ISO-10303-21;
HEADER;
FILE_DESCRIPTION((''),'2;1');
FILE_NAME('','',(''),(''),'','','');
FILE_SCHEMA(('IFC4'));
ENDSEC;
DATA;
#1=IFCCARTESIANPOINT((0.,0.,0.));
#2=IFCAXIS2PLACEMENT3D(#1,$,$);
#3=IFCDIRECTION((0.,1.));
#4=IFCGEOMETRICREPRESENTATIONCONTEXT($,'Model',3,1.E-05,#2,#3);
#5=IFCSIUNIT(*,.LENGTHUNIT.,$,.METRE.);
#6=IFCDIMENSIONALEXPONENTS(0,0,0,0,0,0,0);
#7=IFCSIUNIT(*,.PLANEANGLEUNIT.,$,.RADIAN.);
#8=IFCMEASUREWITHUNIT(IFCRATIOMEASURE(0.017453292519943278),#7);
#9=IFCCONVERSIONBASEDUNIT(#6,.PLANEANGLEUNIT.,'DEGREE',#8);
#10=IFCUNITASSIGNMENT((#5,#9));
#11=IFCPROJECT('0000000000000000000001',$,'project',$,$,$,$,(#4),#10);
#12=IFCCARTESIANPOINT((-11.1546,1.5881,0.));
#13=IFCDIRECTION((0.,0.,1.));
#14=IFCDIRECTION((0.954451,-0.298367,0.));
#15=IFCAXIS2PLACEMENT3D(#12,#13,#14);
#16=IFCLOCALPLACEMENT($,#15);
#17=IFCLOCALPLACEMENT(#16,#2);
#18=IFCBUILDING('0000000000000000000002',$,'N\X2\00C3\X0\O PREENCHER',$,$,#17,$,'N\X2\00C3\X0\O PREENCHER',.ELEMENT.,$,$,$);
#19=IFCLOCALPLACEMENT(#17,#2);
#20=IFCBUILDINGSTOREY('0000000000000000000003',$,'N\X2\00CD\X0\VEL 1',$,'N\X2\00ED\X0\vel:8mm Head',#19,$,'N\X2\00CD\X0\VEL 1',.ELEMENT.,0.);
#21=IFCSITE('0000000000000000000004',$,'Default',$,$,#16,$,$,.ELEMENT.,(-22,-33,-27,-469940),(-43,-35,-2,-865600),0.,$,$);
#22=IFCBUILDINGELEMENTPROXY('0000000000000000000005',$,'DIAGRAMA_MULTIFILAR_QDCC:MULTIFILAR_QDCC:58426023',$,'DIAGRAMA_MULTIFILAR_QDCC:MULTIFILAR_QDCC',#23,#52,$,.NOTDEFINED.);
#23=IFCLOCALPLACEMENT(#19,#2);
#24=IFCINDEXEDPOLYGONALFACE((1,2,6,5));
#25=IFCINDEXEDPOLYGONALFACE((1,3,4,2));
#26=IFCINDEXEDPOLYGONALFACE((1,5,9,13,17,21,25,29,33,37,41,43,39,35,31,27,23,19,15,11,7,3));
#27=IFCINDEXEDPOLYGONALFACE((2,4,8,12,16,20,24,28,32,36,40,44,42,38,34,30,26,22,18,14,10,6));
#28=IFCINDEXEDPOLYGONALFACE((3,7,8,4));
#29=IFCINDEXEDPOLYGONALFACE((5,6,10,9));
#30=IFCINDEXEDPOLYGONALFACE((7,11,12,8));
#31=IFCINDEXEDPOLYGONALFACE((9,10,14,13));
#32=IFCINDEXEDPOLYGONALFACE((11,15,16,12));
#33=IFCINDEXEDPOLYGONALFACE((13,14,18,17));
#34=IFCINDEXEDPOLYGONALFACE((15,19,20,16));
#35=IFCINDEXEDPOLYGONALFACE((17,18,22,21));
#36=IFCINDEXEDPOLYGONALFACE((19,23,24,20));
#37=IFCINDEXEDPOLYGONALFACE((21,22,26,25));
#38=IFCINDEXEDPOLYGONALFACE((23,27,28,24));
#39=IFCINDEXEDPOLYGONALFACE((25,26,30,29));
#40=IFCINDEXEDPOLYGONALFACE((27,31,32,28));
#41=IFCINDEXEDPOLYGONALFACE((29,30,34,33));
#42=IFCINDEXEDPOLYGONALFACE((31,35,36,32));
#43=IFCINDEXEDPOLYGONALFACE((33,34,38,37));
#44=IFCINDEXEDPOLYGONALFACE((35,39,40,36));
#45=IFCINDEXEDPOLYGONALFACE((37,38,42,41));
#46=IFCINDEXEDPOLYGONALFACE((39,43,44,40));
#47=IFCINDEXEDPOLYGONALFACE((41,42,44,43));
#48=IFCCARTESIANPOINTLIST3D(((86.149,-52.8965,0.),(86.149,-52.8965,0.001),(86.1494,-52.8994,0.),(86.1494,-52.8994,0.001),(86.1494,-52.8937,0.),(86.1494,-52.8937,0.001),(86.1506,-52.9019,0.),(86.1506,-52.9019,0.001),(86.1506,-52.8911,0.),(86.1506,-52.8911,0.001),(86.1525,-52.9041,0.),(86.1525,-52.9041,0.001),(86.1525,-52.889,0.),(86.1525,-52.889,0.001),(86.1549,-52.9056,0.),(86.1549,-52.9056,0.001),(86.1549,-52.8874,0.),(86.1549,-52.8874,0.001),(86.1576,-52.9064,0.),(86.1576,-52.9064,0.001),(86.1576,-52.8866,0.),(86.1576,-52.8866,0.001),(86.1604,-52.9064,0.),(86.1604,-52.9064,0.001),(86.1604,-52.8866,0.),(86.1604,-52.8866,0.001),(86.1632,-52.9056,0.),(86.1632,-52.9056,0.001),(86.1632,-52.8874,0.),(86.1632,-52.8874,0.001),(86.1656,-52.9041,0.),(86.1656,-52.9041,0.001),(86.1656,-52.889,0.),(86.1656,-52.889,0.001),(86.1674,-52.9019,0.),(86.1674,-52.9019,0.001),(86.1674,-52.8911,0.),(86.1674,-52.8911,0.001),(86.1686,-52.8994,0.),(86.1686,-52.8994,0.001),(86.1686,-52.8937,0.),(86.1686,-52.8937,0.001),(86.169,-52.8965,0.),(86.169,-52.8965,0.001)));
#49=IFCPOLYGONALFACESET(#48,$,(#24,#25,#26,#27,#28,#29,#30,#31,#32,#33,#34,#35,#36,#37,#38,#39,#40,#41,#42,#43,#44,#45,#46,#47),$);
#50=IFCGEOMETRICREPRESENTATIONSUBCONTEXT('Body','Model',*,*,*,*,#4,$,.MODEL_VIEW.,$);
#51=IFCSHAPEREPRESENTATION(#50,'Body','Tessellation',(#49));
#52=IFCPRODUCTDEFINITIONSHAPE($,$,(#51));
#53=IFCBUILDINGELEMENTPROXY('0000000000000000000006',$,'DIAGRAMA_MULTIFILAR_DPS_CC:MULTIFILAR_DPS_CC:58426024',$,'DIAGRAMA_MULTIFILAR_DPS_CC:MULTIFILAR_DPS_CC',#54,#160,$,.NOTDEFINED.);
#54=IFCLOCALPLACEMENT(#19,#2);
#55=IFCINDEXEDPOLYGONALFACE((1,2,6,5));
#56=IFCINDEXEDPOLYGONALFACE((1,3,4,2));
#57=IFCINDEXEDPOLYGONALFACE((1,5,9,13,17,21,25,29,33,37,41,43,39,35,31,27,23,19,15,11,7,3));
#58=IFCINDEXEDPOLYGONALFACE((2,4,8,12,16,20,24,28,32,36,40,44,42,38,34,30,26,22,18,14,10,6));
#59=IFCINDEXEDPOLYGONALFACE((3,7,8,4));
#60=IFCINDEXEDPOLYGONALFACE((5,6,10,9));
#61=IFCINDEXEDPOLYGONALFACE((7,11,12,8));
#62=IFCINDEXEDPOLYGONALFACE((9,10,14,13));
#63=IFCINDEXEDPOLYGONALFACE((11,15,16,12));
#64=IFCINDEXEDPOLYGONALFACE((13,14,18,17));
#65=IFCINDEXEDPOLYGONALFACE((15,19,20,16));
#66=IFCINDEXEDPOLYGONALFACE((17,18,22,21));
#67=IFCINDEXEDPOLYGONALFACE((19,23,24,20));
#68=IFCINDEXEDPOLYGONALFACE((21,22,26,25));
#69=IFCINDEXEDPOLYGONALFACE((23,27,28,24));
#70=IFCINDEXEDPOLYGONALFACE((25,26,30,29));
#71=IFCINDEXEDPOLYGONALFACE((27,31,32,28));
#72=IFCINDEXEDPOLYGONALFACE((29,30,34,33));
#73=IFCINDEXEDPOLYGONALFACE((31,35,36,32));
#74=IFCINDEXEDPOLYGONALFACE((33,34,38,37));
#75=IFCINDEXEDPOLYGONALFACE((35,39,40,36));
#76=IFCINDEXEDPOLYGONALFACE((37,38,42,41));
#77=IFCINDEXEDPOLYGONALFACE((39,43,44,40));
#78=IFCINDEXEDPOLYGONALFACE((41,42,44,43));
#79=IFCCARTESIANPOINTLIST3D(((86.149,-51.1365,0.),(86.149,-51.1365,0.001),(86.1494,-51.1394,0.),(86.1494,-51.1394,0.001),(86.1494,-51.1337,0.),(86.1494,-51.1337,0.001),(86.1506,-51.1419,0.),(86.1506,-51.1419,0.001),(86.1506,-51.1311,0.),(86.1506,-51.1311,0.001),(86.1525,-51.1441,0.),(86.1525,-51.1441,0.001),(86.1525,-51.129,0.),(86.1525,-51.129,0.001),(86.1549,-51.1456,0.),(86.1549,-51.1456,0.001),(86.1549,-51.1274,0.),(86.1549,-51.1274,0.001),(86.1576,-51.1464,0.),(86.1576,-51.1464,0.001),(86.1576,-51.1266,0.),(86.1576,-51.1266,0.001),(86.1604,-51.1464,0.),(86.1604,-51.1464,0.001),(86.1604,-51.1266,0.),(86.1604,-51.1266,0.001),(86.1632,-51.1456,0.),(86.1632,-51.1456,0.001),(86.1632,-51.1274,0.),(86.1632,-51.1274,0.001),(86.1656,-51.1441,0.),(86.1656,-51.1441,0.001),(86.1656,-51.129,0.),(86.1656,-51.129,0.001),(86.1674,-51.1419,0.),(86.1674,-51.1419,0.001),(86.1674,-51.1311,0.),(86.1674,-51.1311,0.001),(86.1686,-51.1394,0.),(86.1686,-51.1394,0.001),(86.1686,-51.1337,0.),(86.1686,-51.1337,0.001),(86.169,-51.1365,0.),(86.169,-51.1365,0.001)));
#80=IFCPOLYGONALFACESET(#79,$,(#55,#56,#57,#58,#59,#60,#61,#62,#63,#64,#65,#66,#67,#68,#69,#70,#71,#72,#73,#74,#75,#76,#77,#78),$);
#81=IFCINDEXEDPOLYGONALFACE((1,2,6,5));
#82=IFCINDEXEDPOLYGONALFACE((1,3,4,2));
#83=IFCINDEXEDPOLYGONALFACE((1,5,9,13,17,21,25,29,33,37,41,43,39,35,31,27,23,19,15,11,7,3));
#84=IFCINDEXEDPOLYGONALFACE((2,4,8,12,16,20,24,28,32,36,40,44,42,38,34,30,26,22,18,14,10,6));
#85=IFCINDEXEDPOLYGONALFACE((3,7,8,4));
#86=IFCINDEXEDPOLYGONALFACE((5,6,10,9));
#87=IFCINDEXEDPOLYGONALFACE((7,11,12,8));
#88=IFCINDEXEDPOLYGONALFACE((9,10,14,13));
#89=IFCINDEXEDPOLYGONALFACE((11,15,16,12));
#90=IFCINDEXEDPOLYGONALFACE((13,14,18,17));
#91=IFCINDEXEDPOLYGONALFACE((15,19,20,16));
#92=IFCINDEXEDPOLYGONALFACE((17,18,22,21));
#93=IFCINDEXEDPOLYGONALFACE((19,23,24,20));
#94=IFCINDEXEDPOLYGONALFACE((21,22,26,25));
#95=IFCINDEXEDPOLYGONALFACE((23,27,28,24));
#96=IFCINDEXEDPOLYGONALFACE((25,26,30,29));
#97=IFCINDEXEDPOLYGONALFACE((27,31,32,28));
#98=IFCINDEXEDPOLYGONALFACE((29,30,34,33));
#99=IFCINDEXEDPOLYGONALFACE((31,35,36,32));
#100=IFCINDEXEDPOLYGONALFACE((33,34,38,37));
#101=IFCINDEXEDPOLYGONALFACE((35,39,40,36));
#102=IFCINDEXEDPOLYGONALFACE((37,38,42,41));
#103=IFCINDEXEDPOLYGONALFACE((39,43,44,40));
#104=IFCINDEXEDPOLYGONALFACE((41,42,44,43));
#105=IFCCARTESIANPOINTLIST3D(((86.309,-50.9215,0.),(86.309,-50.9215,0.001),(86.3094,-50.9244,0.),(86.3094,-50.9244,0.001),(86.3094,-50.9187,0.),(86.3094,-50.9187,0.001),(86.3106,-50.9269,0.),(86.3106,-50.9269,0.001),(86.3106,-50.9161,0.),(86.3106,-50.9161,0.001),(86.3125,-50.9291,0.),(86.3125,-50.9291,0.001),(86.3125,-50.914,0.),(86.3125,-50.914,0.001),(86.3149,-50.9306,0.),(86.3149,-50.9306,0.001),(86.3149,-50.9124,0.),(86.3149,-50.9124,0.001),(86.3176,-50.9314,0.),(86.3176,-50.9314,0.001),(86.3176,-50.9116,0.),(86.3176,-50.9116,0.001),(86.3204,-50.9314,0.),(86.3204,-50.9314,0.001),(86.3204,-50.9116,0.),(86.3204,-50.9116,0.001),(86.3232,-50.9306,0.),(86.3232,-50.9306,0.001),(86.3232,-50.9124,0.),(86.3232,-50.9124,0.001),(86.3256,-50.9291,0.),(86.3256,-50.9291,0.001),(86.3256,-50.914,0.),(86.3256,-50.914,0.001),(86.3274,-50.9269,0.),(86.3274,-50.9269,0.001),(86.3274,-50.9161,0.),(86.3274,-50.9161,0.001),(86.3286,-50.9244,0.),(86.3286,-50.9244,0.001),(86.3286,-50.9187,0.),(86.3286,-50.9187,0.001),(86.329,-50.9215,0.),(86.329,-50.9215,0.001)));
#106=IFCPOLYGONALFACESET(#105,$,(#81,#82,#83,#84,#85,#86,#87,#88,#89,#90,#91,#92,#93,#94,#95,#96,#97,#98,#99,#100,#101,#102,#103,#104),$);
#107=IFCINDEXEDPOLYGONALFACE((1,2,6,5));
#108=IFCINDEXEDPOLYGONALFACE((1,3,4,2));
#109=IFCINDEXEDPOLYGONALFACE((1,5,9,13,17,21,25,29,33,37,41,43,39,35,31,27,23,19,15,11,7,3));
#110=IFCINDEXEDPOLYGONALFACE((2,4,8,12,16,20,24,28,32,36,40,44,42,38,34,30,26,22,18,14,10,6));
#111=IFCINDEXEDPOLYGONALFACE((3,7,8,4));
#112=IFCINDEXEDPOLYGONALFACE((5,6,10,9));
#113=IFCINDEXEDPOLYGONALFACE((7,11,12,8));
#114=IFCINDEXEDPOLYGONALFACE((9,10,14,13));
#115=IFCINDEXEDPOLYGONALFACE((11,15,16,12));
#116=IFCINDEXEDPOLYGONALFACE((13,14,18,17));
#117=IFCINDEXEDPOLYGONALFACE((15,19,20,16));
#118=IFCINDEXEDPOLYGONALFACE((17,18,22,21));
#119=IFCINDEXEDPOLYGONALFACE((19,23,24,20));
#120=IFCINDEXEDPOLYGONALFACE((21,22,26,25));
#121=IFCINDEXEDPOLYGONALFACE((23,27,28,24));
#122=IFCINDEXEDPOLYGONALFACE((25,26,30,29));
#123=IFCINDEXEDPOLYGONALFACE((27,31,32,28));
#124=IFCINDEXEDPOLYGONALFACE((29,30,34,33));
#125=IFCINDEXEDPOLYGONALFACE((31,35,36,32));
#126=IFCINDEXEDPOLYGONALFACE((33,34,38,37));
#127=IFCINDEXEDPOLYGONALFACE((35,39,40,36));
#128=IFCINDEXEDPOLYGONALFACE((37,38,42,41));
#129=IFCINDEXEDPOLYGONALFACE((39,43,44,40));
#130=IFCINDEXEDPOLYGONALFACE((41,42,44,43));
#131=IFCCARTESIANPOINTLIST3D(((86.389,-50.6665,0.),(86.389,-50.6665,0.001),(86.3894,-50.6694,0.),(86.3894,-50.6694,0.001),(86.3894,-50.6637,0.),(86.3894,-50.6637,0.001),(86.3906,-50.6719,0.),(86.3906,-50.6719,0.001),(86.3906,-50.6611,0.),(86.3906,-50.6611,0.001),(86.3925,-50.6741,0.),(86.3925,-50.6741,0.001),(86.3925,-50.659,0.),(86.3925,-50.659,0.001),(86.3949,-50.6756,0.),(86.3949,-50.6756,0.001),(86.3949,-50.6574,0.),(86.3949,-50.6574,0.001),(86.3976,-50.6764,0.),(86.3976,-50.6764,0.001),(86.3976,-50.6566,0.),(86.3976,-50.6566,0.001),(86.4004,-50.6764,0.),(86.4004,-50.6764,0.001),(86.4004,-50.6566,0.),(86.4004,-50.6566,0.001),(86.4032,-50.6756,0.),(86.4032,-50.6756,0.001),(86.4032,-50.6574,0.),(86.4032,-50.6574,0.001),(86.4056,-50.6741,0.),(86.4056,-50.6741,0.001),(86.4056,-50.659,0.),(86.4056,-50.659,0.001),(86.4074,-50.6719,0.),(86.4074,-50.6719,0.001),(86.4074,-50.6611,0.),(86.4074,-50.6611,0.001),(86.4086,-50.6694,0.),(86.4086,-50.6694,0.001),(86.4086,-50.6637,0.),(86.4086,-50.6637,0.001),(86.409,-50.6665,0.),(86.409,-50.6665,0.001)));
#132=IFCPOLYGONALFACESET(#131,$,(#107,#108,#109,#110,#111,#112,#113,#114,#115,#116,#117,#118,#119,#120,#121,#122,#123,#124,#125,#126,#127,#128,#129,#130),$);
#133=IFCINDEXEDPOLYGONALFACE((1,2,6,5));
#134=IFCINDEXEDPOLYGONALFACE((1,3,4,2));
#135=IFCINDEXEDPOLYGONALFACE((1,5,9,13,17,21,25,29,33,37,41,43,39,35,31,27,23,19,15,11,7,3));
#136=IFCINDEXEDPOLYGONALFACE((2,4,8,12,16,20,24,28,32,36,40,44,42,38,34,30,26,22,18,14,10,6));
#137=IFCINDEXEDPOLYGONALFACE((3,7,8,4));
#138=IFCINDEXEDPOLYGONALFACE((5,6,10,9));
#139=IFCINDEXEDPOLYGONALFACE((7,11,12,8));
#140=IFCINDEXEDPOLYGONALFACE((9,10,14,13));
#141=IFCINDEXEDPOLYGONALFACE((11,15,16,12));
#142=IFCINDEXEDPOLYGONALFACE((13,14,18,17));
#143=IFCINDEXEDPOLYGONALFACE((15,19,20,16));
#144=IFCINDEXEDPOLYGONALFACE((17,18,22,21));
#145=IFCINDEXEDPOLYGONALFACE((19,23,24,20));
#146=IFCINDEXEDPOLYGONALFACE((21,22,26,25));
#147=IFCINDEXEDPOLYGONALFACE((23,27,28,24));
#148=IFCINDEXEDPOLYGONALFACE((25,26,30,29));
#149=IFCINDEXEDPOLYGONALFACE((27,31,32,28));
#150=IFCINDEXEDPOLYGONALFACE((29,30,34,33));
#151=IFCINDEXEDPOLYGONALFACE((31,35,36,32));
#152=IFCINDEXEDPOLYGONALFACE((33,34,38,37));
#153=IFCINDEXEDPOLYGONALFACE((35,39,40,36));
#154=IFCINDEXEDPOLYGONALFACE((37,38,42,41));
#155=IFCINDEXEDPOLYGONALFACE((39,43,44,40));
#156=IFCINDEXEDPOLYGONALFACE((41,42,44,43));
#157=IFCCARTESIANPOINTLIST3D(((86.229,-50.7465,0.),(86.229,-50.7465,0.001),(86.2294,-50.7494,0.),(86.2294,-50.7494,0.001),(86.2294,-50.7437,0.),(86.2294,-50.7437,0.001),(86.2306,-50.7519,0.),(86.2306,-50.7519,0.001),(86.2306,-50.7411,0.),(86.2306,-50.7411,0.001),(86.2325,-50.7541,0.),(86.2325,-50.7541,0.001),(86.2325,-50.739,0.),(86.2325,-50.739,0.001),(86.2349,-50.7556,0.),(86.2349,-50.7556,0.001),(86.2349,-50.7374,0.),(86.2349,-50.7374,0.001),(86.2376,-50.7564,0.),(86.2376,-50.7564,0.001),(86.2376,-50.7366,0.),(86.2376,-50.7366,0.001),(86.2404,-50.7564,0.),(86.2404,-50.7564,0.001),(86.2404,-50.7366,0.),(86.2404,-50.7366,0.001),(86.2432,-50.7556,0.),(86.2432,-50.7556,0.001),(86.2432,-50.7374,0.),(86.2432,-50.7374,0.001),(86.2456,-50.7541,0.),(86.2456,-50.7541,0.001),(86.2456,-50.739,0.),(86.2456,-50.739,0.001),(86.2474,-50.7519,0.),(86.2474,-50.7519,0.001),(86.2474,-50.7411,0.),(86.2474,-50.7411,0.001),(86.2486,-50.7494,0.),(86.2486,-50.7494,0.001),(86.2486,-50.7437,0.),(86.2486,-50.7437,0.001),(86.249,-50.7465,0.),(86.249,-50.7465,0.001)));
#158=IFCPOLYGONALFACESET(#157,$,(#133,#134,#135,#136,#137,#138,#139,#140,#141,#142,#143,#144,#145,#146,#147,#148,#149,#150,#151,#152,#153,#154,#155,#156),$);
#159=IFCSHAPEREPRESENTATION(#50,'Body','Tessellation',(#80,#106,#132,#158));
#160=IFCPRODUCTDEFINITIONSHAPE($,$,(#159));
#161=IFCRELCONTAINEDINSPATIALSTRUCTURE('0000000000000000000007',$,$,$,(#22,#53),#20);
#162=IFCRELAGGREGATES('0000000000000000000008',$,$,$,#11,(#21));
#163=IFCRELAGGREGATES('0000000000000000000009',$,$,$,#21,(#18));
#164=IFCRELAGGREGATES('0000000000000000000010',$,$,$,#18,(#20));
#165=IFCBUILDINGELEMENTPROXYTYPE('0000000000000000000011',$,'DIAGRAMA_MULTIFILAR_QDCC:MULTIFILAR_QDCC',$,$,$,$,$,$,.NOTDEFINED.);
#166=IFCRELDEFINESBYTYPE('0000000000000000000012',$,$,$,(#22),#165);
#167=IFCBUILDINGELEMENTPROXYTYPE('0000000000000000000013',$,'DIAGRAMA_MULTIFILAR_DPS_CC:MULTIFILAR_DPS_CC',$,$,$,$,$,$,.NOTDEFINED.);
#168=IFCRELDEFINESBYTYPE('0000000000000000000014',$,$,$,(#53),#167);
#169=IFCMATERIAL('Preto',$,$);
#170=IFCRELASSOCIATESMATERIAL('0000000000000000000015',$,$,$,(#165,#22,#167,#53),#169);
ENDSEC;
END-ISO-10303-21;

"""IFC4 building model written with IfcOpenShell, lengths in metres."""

from ifc_helpers import new_model, entity, si_unit, converted_unit, direction, frame, origin, place, context, subcontext, project, spatial, arc, indexed_curve, outline, extrude, source, transform, mapped, material, type_object, type_shapes, element, save


model = new_model("IFC4")

# Units and contexts
model_context = context("Model", 3, precision=1e-05, world=origin(), true_north=direction((0.0, 1.0)))
body_context = subcontext(model_context, "Body", "Model", "MODEL_VIEW")
ifc_project = project(units=[si_unit("LENGTHUNIT", "METRE"), converted_unit("PLANEANGLEUNIT", "DEGREE", entity("IfcRatioMeasure", 0.017453292519943278), si_unit("PLANEANGLEUNIT", "RADIAN"), dimensions=[0, 0, 0, 0, 0, 0, 0])], contexts=[model_context])

# Site, building, storey
site_placement = place(None, frame((-11.1546, 1.5881, 0.0), z_axis=(0.0, 0.0, 1.0), x_axis=(0.954451, -0.298367, 0.0)))
site = spatial("IfcSite", under=ifc_project, at=site_placement, Name="Default", CompositionType="ELEMENT", RefLatitude=(-22, -33, -27, -469940), RefLongitude=(-43, -35, -2, -865600), RefElevation=0.0)
building_placement = place(site_placement, origin())
building = spatial("IfcBuilding", under=site, at=building_placement, Name="NÃO PREENCHER", LongName="NÃO PREENCHER", CompositionType="ELEMENT")
storey_placement = place(building_placement, origin())
storey = spatial("IfcBuildingStorey", under=building, at=storey_placement, Name="NÍVEL 1", ObjectType="Nível:8mm Head", LongName="NÍVEL 1", CompositionType="ELEMENT", Elevation=0.0)

# Building element proxies
ifc_material = material(Name="Preto")
building_element_proxy_type_1 = type_object("IfcBuildingElementProxyType", Name="DIAGRAMA_MULTIFILAR_QDCC:MULTIFILAR_QDCC", PredefinedType="NOTDEFINED", material=ifc_material)
shared_shape_1 = source(origin(), body_context, "Body", "SweptSolid", [
    extrude(outline(indexed_curve([(-0.01, 0.0), (0.0, -0.01), (0.01, 0.0), (0.0, 0.01)], segments=[arc(1, 2, 3), arc(3, 4, 1)], self_intersect=False)), frame((0.0116, 0.0116, 0.0)), (0.0, 0.0, 1.0), 0.001),
])
type_shapes(building_element_proxy_type_1, [shared_shape_1])
proxy_1_placement = place(storey_placement, frame((86.1474, -52.9081, 0.0)))
element("IfcBuildingElementProxy", 1, at=proxy_1_placement, inside=storey, type_object=building_element_proxy_type_1, material=ifc_material, Name="DIAGRAMA_MULTIFILAR_QDCC:MULTIFILAR_QDCC:58426023", ObjectType="DIAGRAMA_MULTIFILAR_QDCC:MULTIFILAR_QDCC", PredefinedType="NOTDEFINED", context=body_context, shape_type="MappedRepresentation", body=[
    mapped(shared_shape_1, transform((0.0, 0.0, 0.0), scale=1.0)),
])
building_element_proxy_type_2 = type_object("IfcBuildingElementProxyType", Name="DIAGRAMA_MULTIFILAR_DPS_CC:MULTIFILAR_DPS_CC", PredefinedType="NOTDEFINED", material=ifc_material)
shared_shape_2 = source(origin(), body_context, "Body", "SweptSolid", [
    extrude(outline(indexed_curve([(-0.01, 0.0), (0.0, -0.01), (0.01, 0.0), (0.0, 0.01)], segments=[arc(1, 2, 3), arc(3, 4, 1)], self_intersect=False)), frame((0.0116, 0.0116, 0.0)), (0.0, 0.0, 1.0), 0.001),
    extrude(outline(indexed_curve([(-0.01, 0.0), (0.0, -0.01), (0.01, 0.0), (0.0, 0.01)], segments=[arc(1, 2, 3), arc(3, 4, 1)], self_intersect=False)), frame((0.1716, 0.2266, 0.0)), (0.0, 0.0, 1.0), 0.001),
    extrude(outline(indexed_curve([(-0.01, 0.0), (0.0, -0.01), (0.01, 0.0), (0.0, 0.01)], segments=[arc(1, 2, 3), arc(3, 4, 1)], self_intersect=False)), frame((0.2516, 0.4816, 0.0)), (0.0, 0.0, 1.0), 0.001),
    extrude(outline(indexed_curve([(-0.01, 0.0), (0.0, -0.01), (0.01, 0.0), (0.0, 0.01)], segments=[arc(1, 2, 3), arc(3, 4, 1)], self_intersect=False)), frame((0.0916, 0.4016, 0.0)), (0.0, 0.0, 1.0), 0.001),
])
type_shapes(building_element_proxy_type_2, [shared_shape_2])
for number, where, name in (
    (2, (86.1474, -51.1481, 0.0), "DIAGRAMA_MULTIFILAR_DPS_CC:MULTIFILAR_DPS_CC:58426024"),
):
    element("IfcBuildingElementProxy", number, at=place(storey_placement, frame(where)), inside=storey, type_object=building_element_proxy_type_2, material=ifc_material, Name=name, ObjectType="DIAGRAMA_MULTIFILAR_DPS_CC:MULTIFILAR_DPS_CC", PredefinedType="NOTDEFINED", context=body_context, shape_type="MappedRepresentation", body=[
        mapped(shared_shape_2, transform((0.0, 0.0, 0.0), scale=1.0)),
    ])

save(model, "model.ifc")
